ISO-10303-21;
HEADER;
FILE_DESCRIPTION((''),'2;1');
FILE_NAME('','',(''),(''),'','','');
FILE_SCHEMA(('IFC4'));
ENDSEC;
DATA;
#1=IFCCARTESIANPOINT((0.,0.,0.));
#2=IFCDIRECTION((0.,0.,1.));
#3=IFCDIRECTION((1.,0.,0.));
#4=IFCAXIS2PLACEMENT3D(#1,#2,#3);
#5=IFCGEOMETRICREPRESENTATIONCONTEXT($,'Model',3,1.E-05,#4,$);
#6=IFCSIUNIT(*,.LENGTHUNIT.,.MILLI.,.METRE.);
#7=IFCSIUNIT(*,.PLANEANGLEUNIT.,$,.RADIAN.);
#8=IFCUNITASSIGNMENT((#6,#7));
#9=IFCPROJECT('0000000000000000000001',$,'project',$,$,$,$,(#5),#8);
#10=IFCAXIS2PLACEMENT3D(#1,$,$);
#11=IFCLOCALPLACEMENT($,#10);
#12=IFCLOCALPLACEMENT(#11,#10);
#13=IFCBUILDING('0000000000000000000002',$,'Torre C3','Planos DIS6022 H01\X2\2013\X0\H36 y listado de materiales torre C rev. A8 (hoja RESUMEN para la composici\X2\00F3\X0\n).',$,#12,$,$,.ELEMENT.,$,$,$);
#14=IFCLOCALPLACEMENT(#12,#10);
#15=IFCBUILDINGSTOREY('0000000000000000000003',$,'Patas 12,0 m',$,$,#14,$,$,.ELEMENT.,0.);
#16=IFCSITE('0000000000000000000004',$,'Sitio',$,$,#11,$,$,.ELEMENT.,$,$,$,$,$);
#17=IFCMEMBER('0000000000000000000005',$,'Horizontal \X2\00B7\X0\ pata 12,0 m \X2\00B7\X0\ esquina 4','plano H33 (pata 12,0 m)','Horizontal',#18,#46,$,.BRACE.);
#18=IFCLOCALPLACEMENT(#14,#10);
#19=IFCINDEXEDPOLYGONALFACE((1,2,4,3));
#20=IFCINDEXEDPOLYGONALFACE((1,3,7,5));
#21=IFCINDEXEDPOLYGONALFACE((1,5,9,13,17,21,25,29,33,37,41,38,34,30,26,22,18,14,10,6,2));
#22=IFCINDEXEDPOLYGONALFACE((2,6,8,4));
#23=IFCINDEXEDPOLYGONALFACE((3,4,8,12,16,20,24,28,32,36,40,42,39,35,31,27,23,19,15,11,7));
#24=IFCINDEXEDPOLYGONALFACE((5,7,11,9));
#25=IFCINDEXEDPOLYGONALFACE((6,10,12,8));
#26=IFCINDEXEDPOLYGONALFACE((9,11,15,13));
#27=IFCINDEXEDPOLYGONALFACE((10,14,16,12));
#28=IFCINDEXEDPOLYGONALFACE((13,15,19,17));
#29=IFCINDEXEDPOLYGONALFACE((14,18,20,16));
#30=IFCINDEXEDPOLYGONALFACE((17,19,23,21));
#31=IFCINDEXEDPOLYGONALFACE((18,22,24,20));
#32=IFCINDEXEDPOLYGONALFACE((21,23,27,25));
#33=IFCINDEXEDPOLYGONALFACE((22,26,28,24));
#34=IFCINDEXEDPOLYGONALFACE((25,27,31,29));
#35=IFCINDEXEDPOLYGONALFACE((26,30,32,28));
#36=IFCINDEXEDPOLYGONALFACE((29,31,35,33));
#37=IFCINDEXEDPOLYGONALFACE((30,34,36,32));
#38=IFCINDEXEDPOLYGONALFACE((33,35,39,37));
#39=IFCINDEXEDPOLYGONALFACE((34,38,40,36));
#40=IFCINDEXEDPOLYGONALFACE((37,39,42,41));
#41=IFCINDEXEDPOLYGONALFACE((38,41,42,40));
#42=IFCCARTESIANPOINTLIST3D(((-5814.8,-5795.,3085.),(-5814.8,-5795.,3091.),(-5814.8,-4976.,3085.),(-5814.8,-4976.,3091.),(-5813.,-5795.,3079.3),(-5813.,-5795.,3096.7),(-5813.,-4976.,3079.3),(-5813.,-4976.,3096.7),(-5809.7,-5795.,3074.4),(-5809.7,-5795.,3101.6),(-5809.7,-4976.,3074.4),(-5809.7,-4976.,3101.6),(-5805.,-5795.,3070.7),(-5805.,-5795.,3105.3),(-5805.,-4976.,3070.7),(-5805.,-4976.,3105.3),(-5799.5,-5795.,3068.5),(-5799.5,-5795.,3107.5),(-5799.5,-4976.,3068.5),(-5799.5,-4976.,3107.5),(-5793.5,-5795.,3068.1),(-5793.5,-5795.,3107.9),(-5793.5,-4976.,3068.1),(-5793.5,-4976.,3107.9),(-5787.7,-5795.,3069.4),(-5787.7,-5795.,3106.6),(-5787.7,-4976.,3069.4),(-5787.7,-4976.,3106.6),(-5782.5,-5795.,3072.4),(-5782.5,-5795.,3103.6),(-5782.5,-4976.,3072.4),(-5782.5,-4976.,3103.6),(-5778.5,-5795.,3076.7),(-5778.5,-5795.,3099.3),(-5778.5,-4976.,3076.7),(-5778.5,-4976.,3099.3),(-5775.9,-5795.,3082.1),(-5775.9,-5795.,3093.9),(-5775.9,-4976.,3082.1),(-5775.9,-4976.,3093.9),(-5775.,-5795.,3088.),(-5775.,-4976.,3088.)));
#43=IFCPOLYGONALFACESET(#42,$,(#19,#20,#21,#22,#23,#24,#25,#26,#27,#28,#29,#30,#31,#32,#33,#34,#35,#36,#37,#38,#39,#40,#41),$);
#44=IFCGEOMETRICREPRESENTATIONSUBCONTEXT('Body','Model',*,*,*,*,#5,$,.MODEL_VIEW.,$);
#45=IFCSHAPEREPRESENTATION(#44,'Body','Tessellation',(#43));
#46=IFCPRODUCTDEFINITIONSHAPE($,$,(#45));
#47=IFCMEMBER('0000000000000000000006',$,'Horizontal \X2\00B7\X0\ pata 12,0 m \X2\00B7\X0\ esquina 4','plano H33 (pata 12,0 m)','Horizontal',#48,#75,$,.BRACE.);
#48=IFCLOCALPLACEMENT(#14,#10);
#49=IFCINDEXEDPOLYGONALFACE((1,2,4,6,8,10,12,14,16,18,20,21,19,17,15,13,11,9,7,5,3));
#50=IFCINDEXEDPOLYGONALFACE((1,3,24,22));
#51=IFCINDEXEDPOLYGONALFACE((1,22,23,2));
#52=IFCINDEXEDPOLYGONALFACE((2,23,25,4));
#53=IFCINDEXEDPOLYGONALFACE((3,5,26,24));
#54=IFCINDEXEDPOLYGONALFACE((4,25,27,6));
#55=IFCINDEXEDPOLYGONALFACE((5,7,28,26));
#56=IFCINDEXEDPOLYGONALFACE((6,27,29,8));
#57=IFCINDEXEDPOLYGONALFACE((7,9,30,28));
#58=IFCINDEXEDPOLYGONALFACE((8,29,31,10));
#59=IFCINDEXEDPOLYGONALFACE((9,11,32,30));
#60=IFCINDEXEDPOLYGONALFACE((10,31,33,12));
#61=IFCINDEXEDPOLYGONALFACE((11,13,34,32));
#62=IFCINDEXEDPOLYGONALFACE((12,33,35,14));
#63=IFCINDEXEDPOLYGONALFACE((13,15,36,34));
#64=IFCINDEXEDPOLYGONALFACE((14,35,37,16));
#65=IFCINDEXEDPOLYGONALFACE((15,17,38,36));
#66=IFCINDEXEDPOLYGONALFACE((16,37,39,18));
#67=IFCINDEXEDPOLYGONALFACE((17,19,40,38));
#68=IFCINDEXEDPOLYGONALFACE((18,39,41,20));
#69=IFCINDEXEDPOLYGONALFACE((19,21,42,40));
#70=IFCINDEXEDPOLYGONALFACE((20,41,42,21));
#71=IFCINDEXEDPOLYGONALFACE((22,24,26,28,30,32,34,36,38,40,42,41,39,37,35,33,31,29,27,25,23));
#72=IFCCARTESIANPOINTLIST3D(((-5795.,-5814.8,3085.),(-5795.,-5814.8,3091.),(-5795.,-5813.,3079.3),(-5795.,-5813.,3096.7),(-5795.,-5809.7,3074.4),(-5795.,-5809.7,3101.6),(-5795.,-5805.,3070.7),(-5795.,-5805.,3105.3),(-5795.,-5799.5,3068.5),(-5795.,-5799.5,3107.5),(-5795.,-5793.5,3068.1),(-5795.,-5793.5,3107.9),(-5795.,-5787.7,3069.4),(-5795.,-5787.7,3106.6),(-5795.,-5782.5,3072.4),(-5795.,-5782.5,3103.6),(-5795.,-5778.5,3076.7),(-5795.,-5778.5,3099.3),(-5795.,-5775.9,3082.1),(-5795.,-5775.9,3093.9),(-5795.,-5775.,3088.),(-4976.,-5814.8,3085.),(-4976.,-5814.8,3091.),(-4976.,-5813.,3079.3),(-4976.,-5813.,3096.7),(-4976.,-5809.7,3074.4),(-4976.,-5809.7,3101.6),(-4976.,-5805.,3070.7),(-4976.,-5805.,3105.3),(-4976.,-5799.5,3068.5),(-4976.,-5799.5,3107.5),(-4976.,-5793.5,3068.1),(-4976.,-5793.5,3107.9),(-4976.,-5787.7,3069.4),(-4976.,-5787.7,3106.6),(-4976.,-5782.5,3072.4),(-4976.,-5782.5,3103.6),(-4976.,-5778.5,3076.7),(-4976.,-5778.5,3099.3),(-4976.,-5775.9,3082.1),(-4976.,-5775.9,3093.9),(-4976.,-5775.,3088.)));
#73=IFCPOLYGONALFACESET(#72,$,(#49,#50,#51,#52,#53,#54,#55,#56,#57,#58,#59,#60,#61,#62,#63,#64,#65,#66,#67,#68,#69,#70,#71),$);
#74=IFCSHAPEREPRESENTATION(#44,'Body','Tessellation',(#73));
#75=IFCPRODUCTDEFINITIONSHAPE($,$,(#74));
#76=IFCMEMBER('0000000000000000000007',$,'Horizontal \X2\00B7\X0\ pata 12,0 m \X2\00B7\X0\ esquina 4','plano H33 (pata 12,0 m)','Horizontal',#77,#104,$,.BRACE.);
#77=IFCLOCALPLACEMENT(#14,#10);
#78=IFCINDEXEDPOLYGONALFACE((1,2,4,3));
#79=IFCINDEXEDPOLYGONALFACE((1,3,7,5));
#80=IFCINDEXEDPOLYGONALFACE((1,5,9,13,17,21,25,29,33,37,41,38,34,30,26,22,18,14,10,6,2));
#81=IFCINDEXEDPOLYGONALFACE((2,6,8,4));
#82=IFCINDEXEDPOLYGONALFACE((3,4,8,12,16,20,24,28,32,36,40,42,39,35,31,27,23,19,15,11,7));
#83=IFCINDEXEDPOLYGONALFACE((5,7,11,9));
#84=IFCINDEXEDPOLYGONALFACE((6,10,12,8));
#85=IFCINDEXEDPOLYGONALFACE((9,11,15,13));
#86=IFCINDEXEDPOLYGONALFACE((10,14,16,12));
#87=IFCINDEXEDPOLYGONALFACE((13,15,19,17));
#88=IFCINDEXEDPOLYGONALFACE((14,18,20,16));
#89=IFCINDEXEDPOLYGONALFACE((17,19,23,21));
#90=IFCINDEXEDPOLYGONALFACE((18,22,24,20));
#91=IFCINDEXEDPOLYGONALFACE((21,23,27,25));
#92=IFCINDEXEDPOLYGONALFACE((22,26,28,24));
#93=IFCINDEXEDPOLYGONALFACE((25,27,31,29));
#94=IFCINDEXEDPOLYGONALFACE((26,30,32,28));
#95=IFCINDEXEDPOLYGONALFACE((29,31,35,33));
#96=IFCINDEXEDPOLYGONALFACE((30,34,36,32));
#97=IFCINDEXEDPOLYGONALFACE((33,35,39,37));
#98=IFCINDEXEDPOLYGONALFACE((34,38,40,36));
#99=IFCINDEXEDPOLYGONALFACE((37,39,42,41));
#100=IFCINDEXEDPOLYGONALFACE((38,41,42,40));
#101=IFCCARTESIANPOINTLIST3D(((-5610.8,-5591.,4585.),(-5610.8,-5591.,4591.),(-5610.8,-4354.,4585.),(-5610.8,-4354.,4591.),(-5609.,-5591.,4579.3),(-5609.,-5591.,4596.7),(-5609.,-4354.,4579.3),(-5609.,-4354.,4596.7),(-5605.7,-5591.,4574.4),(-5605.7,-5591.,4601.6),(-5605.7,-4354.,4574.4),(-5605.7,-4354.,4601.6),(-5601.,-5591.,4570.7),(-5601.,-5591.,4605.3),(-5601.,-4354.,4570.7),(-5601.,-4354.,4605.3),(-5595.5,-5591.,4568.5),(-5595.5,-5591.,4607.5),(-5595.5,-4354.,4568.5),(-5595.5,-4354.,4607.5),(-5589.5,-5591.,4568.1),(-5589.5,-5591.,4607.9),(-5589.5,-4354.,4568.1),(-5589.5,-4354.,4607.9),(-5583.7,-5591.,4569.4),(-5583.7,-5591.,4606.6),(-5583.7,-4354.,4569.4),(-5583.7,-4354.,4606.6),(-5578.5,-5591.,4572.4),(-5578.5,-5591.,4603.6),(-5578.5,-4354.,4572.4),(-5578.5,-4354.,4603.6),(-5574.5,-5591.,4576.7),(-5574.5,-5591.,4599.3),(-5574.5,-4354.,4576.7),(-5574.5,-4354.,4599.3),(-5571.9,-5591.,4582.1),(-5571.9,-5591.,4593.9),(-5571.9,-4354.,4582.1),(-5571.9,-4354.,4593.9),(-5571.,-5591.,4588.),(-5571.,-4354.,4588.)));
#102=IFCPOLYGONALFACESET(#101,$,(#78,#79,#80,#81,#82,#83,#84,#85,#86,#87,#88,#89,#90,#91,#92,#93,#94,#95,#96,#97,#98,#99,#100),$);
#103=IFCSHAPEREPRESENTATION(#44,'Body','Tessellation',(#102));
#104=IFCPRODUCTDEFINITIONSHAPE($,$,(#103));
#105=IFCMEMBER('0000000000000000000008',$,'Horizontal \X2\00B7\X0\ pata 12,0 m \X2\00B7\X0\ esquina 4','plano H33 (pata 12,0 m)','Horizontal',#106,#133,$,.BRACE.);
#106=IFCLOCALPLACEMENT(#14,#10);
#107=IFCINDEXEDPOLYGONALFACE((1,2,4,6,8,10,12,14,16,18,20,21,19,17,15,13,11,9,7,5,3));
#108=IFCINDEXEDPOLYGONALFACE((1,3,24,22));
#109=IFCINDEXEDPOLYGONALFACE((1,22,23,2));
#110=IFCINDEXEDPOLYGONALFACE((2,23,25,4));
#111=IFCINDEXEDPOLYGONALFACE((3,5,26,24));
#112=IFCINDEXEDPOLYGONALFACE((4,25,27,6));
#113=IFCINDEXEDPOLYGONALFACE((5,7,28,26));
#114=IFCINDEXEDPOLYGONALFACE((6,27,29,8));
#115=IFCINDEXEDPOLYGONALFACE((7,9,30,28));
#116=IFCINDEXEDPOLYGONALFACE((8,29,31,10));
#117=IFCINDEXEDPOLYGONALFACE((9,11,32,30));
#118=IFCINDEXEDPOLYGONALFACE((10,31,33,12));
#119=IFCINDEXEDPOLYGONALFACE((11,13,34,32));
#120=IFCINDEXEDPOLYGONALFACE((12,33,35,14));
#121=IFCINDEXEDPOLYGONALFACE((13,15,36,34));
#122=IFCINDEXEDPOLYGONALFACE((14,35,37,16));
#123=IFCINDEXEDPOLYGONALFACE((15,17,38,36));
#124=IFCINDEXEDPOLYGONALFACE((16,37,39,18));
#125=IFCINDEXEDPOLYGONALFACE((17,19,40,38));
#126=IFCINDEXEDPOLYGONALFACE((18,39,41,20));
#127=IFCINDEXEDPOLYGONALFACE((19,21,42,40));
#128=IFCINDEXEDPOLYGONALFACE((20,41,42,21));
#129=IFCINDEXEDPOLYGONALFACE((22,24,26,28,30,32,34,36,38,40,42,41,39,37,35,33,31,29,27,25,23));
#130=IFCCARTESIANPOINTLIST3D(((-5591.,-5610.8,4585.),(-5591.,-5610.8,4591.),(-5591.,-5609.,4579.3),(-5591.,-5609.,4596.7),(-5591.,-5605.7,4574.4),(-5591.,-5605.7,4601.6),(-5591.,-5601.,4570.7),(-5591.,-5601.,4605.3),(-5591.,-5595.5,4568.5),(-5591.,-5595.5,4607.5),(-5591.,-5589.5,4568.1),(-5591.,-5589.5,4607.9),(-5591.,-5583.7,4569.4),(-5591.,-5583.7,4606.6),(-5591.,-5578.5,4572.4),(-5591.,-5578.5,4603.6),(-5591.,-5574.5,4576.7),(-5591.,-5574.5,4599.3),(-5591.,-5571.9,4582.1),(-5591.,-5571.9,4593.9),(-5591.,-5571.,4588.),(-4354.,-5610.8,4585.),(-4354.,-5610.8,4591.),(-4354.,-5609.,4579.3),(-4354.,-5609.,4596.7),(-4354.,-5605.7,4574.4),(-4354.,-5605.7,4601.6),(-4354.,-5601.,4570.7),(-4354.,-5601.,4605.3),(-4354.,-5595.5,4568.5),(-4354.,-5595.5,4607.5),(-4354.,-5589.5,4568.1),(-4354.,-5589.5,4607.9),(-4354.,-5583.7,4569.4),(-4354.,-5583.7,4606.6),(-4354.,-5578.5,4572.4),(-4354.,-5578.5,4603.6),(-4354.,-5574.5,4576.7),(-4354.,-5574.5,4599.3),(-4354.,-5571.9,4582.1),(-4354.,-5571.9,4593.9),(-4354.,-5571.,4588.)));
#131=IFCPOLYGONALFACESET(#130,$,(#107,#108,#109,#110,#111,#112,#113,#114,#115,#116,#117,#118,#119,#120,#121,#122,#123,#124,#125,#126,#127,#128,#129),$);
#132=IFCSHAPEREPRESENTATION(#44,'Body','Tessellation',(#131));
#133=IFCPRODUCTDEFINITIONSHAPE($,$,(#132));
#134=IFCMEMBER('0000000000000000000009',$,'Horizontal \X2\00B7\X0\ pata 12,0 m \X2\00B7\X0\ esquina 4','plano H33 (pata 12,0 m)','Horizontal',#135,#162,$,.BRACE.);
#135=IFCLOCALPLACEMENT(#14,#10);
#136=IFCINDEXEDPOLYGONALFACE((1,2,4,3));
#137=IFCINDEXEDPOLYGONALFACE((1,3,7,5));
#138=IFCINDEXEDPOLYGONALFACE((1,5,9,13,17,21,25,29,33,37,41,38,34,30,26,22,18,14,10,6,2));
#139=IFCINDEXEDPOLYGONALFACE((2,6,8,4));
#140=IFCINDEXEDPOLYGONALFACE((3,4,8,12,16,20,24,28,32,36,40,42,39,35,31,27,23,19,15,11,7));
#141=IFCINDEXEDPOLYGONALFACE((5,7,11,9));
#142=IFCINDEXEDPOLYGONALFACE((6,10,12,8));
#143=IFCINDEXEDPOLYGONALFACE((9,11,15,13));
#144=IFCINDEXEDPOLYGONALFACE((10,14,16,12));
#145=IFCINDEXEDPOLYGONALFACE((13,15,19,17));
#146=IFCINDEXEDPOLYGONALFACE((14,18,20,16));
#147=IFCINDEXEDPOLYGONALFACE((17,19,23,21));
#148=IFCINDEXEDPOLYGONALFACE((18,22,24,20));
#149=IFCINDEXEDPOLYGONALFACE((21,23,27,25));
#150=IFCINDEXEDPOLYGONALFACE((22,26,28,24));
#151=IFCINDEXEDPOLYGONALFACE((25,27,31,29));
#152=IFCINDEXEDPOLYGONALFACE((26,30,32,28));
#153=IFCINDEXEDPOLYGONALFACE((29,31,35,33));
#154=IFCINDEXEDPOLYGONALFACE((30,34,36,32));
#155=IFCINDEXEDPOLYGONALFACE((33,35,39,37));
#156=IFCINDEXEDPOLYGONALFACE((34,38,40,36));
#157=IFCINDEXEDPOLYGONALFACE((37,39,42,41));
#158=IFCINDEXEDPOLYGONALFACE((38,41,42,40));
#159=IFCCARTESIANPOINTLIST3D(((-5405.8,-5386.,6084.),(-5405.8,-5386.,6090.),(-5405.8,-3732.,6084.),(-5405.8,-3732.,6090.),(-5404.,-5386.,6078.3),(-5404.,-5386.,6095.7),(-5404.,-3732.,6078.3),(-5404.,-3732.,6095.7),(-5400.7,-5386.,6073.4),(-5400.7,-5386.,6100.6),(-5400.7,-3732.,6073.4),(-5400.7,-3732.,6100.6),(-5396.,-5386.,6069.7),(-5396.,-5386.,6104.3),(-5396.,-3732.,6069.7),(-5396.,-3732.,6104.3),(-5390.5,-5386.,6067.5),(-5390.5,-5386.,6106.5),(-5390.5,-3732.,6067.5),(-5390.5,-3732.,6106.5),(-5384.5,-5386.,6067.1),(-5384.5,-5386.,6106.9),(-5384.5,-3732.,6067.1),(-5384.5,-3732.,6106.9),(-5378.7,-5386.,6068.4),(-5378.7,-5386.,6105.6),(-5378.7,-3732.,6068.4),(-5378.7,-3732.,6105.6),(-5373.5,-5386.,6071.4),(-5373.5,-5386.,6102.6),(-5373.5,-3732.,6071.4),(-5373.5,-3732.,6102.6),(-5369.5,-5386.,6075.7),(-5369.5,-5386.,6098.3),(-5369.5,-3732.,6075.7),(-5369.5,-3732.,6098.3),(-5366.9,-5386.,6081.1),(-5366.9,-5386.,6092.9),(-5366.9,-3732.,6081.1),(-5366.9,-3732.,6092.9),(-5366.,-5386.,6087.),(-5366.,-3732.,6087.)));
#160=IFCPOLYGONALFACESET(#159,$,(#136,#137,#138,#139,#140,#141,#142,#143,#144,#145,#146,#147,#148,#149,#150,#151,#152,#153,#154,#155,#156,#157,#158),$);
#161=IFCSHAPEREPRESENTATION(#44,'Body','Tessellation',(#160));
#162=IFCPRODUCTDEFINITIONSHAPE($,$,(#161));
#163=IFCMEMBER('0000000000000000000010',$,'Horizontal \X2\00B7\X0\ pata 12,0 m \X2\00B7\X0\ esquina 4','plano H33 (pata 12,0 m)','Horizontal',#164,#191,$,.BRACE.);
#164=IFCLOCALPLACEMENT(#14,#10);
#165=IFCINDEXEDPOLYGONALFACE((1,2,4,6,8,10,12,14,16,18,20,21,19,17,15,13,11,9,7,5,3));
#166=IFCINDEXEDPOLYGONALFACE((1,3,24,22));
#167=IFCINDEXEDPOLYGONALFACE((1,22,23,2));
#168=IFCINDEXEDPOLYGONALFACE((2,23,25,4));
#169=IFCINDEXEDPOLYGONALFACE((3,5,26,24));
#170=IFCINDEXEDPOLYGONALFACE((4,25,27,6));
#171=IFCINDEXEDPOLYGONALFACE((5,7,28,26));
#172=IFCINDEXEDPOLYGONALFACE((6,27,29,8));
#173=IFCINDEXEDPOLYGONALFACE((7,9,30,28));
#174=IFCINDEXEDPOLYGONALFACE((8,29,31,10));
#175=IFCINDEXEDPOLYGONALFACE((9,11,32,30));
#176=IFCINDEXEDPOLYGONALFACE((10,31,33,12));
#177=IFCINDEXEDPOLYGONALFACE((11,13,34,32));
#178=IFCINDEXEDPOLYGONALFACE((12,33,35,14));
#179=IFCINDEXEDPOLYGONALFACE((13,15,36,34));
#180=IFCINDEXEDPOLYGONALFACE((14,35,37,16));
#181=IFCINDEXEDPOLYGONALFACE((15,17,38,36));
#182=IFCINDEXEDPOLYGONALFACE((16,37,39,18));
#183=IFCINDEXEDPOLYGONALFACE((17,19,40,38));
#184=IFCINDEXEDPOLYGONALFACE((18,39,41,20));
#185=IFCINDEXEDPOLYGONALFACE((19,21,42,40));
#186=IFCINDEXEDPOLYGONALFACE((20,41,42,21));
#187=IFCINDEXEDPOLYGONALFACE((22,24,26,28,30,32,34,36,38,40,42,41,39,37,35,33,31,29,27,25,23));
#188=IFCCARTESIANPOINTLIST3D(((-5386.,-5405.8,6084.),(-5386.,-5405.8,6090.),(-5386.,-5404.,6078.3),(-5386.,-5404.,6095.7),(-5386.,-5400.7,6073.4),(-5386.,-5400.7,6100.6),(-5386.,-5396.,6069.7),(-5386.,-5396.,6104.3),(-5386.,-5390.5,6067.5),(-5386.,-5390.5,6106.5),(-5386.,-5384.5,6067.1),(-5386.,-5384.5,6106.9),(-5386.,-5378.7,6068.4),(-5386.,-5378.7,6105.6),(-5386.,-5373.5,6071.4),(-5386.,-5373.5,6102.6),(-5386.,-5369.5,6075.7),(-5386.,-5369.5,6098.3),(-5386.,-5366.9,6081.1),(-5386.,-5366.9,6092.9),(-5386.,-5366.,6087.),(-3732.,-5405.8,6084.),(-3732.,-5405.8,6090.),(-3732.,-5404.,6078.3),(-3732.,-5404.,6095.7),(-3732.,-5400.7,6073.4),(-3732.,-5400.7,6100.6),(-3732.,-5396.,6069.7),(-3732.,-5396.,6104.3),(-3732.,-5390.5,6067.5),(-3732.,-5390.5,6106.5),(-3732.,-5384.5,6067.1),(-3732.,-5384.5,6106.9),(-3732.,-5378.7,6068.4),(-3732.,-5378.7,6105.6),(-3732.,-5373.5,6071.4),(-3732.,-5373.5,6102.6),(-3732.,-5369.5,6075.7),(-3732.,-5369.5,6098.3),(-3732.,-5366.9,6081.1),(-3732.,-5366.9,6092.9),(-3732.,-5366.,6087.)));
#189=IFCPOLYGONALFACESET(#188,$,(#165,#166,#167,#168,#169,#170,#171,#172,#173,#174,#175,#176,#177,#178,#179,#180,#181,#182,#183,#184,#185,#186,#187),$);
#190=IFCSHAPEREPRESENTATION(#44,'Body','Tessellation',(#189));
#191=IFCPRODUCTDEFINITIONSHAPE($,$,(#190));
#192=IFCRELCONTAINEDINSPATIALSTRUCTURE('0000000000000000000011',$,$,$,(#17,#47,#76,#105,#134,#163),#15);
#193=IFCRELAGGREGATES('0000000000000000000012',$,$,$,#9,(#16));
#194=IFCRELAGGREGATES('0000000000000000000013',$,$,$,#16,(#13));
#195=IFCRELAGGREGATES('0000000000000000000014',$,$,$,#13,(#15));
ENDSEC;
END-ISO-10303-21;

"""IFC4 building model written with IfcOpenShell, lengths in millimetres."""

from ifc_helpers import new_model, si_unit, frame, origin, origin_with_axes, place, context, subcontext, project, spatial, circle, extrude, element, save


model = new_model("IFC4")

# Units and contexts
model_context = context("Model", 3, precision=1e-05, world=origin_with_axes())
body_context = subcontext(model_context, "Body", "Model", "MODEL_VIEW")
ifc_project = project(units=[si_unit("LENGTHUNIT", "METRE", prefix="MILLI"), si_unit("PLANEANGLEUNIT", "RADIAN")], contexts=[model_context])

# Site, building, storey
site_placement = place(None, origin())
site = spatial("IfcSite", under=ifc_project, at=site_placement, Name="Sitio", CompositionType="ELEMENT")
building_placement = place(site_placement, origin())
building = spatial("IfcBuilding", under=site, at=building_placement, Name="Torre C3", Description="Planos DIS6022 H01–H36 y listado de materiales torre C rev. A8 (hoja RESUMEN para la composición).", CompositionType="ELEMENT")
storey_placement = place(building_placement, origin())
storey = spatial("IfcBuildingStorey", under=building, at=storey_placement, Name="Patas 12,0 m", CompositionType="ELEMENT", Elevation=0.0)

# Members
for number, where, z_axis, x_axis, name in (
    (1, (-5795.0, -5795.0, 3088.0), (0.0, 1.0, 0.0), (1.0, 0.0, 0.0), "Horizontal · pata 12,0 m · esquina 4"),
    (2, (-5795.0, -5795.0, 3088.0), (1.0, 0.0, 0.0), (0.0, 1.0, 0.0), "Horizontal · pata 12,0 m · esquina 4"),
):
    element("IfcMember", number, at=place(storey_placement, frame(where, z_axis=z_axis, x_axis=x_axis)), inside=storey, Name=name, Description="plano H33 (pata 12,0 m)", ObjectType="Horizontal", PredefinedType="BRACE", context=body_context, shape_type="SweptSolid", body=[
        extrude(circle(Radius=20.0), None, (0.0, 0.0, 1.0), 819.0),
    ])
for number, where, z_axis, x_axis, name in (
    (3, (-5591.0, -5591.0, 4588.0), (0.0, 1.0, 0.0), (1.0, 0.0, 0.0), "Horizontal · pata 12,0 m · esquina 4"),
    (4, (-5591.0, -5591.0, 4588.0), (1.0, 0.0, 0.0), (0.0, 1.0, 0.0), "Horizontal · pata 12,0 m · esquina 4"),
):
    element("IfcMember", number, at=place(storey_placement, frame(where, z_axis=z_axis, x_axis=x_axis)), inside=storey, Name=name, Description="plano H33 (pata 12,0 m)", ObjectType="Horizontal", PredefinedType="BRACE", context=body_context, shape_type="SweptSolid", body=[
        extrude(circle(Radius=20.0), None, (0.0, 0.0, 1.0), 1237.0),
    ])
for number, where, z_axis, x_axis, name in (
    (5, (-5386.0, -3732.0, 6087.0), (0.0, -1.0, 0.0), (1.0, 0.0, 0.0), "Horizontal · pata 12,0 m · esquina 4"),
    (6, (-3732.0, -5386.0, 6087.0), (-1.0, 0.0, 0.0), (0.0, 1.0, 0.0), "Horizontal · pata 12,0 m · esquina 4"),
):
    element("IfcMember", number, at=place(storey_placement, frame(where, z_axis=z_axis, x_axis=x_axis)), inside=storey, Name=name, Description="plano H33 (pata 12,0 m)", ObjectType="Horizontal", PredefinedType="BRACE", context=body_context, shape_type="SweptSolid", body=[
        extrude(circle(Radius=20.0), None, (0.0, 0.0, 1.0), 1654.0),
    ])

save(model, "model.ifc")
